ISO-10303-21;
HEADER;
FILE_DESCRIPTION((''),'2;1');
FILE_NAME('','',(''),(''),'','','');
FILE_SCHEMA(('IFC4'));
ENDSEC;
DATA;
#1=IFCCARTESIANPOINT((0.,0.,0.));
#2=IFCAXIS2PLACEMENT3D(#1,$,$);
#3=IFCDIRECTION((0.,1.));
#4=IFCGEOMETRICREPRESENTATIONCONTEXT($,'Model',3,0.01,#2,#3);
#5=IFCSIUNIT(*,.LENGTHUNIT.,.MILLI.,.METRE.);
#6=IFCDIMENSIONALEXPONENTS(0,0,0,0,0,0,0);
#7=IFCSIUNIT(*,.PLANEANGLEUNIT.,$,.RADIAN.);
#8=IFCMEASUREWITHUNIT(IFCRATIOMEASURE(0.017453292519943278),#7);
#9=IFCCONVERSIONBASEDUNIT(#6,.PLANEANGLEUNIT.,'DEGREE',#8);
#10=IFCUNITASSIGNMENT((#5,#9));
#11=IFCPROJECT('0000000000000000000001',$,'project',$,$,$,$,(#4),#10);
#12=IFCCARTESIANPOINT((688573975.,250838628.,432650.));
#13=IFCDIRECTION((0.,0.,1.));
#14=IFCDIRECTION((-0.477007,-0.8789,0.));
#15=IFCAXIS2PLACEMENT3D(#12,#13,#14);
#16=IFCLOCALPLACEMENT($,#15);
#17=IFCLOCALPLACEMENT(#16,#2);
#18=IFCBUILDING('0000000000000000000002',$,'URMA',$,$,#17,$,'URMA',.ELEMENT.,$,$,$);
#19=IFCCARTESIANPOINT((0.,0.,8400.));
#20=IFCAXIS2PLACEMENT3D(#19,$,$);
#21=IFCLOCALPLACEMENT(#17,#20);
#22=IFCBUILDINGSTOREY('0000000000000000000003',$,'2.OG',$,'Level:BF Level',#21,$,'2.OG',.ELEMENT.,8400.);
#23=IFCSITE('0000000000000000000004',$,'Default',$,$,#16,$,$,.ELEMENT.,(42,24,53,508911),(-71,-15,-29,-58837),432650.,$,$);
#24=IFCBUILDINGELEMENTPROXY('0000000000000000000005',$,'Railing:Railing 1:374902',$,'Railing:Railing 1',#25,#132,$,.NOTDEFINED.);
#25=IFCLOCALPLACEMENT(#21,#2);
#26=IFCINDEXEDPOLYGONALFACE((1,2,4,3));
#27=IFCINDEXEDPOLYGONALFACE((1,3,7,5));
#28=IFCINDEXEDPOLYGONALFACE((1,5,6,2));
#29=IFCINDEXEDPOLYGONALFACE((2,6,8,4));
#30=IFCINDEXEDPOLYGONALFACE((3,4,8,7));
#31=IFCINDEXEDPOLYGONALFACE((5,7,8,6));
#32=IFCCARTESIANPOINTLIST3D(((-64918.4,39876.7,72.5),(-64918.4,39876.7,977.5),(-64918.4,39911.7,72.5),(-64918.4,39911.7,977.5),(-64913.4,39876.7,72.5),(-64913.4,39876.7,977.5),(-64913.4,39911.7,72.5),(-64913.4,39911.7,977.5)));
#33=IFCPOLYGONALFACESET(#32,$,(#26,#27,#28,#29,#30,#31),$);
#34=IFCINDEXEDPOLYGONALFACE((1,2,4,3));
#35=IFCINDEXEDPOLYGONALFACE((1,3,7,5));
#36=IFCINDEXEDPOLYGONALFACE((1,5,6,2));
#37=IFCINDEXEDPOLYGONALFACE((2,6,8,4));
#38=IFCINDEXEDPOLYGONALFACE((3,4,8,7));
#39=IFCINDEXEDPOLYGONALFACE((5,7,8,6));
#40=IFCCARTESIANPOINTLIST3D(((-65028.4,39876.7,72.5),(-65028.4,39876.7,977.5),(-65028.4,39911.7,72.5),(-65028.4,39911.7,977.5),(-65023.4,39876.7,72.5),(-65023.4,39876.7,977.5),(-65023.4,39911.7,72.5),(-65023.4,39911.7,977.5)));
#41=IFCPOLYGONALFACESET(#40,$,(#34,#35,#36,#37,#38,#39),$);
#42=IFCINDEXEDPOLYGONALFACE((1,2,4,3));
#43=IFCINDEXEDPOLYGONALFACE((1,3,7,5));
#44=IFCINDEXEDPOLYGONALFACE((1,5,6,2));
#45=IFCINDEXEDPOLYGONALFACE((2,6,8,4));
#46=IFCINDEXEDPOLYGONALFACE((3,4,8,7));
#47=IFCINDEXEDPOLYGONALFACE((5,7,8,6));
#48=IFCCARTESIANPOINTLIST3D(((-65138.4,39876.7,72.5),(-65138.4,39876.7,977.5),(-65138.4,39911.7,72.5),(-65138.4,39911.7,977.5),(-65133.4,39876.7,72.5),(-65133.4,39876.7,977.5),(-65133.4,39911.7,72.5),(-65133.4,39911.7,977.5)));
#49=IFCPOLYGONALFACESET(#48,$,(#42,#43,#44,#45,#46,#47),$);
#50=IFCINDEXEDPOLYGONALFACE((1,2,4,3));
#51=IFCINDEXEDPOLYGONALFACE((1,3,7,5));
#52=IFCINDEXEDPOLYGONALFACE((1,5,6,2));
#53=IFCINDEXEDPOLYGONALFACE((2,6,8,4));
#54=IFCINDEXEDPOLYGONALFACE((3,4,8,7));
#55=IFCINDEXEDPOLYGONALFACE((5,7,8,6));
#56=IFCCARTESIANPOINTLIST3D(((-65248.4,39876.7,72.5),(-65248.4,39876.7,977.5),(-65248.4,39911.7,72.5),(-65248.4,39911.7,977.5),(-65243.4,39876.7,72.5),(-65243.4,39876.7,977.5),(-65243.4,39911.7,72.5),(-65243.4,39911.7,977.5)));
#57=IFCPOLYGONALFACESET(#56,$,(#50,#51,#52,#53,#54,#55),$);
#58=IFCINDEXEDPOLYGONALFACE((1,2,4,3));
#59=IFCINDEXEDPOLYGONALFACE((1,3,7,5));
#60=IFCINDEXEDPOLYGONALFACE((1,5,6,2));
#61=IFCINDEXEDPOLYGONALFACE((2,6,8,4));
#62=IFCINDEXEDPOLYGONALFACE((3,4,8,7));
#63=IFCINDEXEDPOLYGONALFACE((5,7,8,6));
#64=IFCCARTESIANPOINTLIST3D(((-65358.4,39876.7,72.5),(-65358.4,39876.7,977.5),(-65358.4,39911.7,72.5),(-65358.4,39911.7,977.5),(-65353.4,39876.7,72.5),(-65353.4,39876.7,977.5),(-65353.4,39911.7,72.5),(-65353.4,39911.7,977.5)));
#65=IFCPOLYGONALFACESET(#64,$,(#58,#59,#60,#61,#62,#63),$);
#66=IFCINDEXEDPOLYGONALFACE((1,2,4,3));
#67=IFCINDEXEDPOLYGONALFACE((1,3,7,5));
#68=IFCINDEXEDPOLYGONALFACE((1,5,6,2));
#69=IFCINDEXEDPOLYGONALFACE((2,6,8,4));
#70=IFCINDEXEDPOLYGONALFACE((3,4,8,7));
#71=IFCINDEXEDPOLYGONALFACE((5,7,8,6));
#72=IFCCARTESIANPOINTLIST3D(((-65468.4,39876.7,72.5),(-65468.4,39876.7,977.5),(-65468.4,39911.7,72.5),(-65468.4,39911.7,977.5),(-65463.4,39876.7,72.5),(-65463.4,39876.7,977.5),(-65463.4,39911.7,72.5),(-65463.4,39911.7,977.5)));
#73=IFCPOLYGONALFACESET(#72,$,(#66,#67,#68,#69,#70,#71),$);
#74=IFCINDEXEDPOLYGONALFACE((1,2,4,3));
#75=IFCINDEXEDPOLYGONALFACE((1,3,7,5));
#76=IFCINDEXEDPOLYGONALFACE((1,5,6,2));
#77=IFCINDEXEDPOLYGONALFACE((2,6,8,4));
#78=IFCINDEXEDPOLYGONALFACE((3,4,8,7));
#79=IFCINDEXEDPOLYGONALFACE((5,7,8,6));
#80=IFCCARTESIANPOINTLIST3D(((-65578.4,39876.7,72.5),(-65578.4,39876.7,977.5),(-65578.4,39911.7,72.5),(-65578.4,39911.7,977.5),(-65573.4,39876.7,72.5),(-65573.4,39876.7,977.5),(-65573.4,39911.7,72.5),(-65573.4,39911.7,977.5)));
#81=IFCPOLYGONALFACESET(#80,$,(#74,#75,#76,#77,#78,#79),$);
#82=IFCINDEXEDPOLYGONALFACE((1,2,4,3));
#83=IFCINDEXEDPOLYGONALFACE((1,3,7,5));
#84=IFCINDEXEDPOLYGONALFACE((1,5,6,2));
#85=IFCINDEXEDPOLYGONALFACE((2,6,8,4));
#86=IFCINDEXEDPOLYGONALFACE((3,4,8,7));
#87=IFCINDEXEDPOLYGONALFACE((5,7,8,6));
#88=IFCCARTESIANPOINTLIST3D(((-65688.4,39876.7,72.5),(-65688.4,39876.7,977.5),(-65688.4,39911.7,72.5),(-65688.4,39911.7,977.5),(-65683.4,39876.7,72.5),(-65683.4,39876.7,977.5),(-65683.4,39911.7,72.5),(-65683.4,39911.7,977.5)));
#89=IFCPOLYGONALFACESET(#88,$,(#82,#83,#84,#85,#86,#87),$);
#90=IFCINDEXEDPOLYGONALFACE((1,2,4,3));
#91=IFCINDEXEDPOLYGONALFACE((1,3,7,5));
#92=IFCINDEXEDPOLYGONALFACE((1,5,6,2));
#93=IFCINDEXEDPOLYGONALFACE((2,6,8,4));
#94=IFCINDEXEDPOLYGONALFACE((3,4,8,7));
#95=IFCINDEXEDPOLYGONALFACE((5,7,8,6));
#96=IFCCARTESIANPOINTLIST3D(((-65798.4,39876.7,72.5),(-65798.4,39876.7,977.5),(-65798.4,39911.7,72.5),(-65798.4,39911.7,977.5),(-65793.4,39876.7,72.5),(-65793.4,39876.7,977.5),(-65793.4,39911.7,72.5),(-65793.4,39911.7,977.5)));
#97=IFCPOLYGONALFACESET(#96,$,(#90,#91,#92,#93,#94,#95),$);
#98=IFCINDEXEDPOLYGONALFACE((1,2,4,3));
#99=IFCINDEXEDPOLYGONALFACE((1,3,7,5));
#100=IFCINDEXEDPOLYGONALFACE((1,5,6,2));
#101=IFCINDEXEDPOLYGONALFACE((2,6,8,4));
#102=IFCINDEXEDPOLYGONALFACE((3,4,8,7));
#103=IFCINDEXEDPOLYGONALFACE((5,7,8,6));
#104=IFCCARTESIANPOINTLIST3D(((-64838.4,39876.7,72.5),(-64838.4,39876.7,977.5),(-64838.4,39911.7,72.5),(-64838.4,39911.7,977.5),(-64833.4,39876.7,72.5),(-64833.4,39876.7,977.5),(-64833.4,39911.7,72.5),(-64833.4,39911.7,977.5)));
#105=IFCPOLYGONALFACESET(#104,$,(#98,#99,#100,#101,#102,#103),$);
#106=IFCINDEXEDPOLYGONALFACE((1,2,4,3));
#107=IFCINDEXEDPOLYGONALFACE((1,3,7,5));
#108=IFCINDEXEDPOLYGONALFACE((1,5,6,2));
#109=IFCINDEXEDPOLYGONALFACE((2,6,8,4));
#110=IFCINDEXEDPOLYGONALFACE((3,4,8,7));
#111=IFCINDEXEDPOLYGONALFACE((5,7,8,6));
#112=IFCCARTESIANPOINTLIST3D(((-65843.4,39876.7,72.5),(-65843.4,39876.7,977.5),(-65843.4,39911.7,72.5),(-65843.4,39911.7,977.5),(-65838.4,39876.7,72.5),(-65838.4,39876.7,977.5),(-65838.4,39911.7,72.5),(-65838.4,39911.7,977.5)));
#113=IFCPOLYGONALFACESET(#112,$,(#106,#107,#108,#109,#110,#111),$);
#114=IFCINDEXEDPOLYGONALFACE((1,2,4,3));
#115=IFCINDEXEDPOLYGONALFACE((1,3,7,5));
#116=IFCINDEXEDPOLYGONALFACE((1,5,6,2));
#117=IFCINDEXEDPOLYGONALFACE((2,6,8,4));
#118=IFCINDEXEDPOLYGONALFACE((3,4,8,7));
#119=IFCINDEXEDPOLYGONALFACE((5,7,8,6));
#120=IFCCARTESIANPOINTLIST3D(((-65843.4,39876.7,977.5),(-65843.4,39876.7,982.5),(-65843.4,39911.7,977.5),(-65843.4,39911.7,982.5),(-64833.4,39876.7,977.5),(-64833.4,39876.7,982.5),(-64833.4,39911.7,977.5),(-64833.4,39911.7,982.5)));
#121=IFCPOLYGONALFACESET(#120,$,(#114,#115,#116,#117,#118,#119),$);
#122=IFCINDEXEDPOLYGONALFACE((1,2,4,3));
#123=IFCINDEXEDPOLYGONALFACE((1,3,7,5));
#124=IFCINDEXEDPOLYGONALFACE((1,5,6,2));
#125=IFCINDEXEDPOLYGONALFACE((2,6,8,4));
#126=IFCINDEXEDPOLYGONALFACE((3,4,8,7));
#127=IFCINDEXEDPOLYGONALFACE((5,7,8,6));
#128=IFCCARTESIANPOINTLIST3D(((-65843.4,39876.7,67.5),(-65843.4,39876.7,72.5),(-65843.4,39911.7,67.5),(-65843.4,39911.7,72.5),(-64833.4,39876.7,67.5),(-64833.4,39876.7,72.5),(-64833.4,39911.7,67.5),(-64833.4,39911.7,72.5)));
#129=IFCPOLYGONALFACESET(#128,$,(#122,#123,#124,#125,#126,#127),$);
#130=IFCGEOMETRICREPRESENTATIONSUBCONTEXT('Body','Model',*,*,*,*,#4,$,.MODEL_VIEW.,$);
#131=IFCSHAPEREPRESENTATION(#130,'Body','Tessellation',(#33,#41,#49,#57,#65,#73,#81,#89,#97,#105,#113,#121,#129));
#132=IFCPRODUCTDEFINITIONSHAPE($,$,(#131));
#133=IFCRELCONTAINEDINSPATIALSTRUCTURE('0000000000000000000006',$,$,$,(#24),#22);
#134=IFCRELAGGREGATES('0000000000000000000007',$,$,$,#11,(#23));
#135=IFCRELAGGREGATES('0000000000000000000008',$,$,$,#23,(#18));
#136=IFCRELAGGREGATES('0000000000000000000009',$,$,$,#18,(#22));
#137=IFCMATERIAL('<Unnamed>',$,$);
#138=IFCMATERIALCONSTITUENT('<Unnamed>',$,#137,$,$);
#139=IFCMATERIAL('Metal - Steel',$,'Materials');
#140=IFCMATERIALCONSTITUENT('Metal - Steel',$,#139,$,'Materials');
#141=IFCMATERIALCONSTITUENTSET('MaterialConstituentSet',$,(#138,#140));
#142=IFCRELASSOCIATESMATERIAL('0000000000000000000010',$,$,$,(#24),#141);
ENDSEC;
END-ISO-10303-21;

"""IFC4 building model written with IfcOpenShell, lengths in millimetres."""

from ifc_helpers import new_model, entity, si_unit, converted_unit, direction, frame, origin, place, context, subcontext, project, spatial, indexed_curve, outline, extrude, material, constituent, constituent_set, element, save


model = new_model("IFC4")

# Units and contexts
model_context = context("Model", 3, precision=0.01, world=origin(), true_north=direction((0.0, 1.0)))
body_context = subcontext(model_context, "Body", "Model", "MODEL_VIEW")
ifc_project = project(units=[si_unit("LENGTHUNIT", "METRE", prefix="MILLI"), converted_unit("PLANEANGLEUNIT", "DEGREE", entity("IfcRatioMeasure", 0.017453292519943278), si_unit("PLANEANGLEUNIT", "RADIAN"), dimensions=[0, 0, 0, 0, 0, 0, 0])], contexts=[model_context])

# Site, building, storey
site_placement = place(None, frame((688573975.0, 250838628.0, 432650.0), z_axis=(0.0, 0.0, 1.0), x_axis=(-0.477007, -0.8789, 0.0)))
site = spatial("IfcSite", under=ifc_project, at=site_placement, Name="Default", CompositionType="ELEMENT", RefLatitude=(42, 24, 53, 508911), RefLongitude=(-71, -15, -29, -58837), RefElevation=432650.0)
building_placement = place(site_placement, origin())
building = spatial("IfcBuilding", under=site, at=building_placement, Name="URMA", LongName="URMA", CompositionType="ELEMENT")
storey_placement = place(building_placement, frame((0.0, 0.0, 8400.0)))
storey = spatial("IfcBuildingStorey", under=building, at=storey_placement, Name="2.OG", ObjectType="Level:BF Level", LongName="2.OG", CompositionType="ELEMENT", Elevation=8400.0)

# Building element proxy
ifc_material_1 = material(Name="<Unnamed>")
ifc_material_2 = material(Name="Metal - Steel", Category="Materials")
ifc_constituent_1 = constituent(ifc_material_1, Name="<Unnamed>")
ifc_constituent_2 = constituent(ifc_material_2, Name="Metal - Steel", Category="Materials")
ifc_constituent_set_1 = constituent_set(constituents=[ifc_constituent_1, ifc_constituent_2], Name="MaterialConstituentSet")
proxy_1_placement = place(storey_placement, origin())
element("IfcBuildingElementProxy", 1, at=proxy_1_placement, inside=storey, material=ifc_constituent_set_1, Name="Railing:Railing 1:374902", ObjectType="Railing:Railing 1", PredefinedType="NOTDEFINED", context=body_context, shape_type="SweptSolid", body=[
    extrude(outline(indexed_curve([(-17.5, -2.5), (17.5, -2.5), (17.5, 2.5), (-17.5, 2.5), (-17.5, -2.5)], self_intersect=False)), frame((-64915.9, 39894.2, 72.5), z_axis=(0.0, 0.0, 1.0), x_axis=(0.0, 1.0, 0.0)), (0.0, 0.0, 1.0), 905.0),
    extrude(outline(indexed_curve([(-17.5, -2.5), (17.5, -2.5), (17.5, 2.5), (-17.5, 2.5), (-17.5, -2.5)], self_intersect=False)), frame((-65025.9, 39894.2, 72.5), z_axis=(0.0, 0.0, 1.0), x_axis=(0.0, 1.0, 0.0)), (0.0, 0.0, 1.0), 905.0),
    extrude(outline(indexed_curve([(-17.5, -2.5), (17.5, -2.5), (17.5, 2.5), (-17.5, 2.5), (-17.5, -2.5)], self_intersect=False)), frame((-65135.9, 39894.2, 72.5), z_axis=(0.0, 0.0, 1.0), x_axis=(0.0, 1.0, 0.0)), (0.0, 0.0, 1.0), 905.0),
    extrude(outline(indexed_curve([(-17.5, -2.5), (17.5, -2.5), (17.5, 2.5), (-17.5, 2.5), (-17.5, -2.5)], self_intersect=False)), frame((-65245.9, 39894.2, 72.5), z_axis=(0.0, 0.0, 1.0), x_axis=(0.0, 1.0, 0.0)), (0.0, 0.0, 1.0), 905.0),
    extrude(outline(indexed_curve([(-17.5, -2.5), (17.5, -2.5), (17.5, 2.5), (-17.5, 2.5), (-17.5, -2.5)], self_intersect=False)), frame((-65355.9, 39894.2, 72.5), z_axis=(0.0, 0.0, 1.0), x_axis=(0.0, 1.0, 0.0)), (0.0, 0.0, 1.0), 905.0),
    extrude(outline(indexed_curve([(-17.5, -2.5), (17.5, -2.5), (17.5, 2.5), (-17.5, 2.5), (-17.5, -2.5)], self_intersect=False)), frame((-65465.9, 39894.2, 72.5), z_axis=(0.0, 0.0, 1.0), x_axis=(0.0, 1.0, 0.0)), (0.0, 0.0, 1.0), 905.0),
    extrude(outline(indexed_curve([(-17.5, -2.5), (17.5, -2.5), (17.5, 2.5), (-17.5, 2.5), (-17.5, -2.5)], self_intersect=False)), frame((-65575.9, 39894.2, 72.5), z_axis=(0.0, 0.0, 1.0), x_axis=(0.0, 1.0, 0.0)), (0.0, 0.0, 1.0), 905.0),
    extrude(outline(indexed_curve([(-17.5, -2.5), (17.5, -2.5), (17.5, 2.5), (-17.5, 2.5), (-17.5, -2.5)], self_intersect=False)), frame((-65685.9, 39894.2, 72.5), z_axis=(0.0, 0.0, 1.0), x_axis=(0.0, 1.0, 0.0)), (0.0, 0.0, 1.0), 905.0),
    extrude(outline(indexed_curve([(-17.5, -2.5), (17.5, -2.5), (17.5, 2.5), (-17.5, 2.5), (-17.5, -2.5)], self_intersect=False)), frame((-65795.9, 39894.2, 72.5), z_axis=(0.0, 0.0, 1.0), x_axis=(0.0, 1.0, 0.0)), (0.0, 0.0, 1.0), 905.0),
    extrude(outline(indexed_curve([(-17.5, -2.5), (17.5, -2.5), (17.5, 2.5), (-17.5, 2.5), (-17.5, -2.5)], self_intersect=False)), frame((-64835.9, 39894.2, 72.5), z_axis=(0.0, 0.0, 1.0), x_axis=(0.0, 1.0, 0.0)), (0.0, 0.0, 1.0), 905.0),
    extrude(outline(indexed_curve([(-17.5, -2.5), (17.5, -2.5), (17.5, 2.5), (-17.5, 2.5), (-17.5, -2.5)], self_intersect=False)), frame((-65840.9, 39894.2, 72.5), z_axis=(0.0, 0.0, 1.0), x_axis=(0.0, 1.0, 0.0)), (0.0, 0.0, 1.0), 905.0),
    extrude(outline(indexed_curve([(-505.0, -17.5), (505.0, -17.5), (505.0, 17.5), (-505.0, 17.5), (-505.0, -17.5)], self_intersect=False)), frame((-65338.4, 39894.2, 977.5)), (0.0, 0.0, 1.0), 5.0),
    extrude(outline(indexed_curve([(-505.0, -17.5), (505.0, -17.5), (505.0, 17.5), (-505.0, 17.5), (-505.0, -17.5)], self_intersect=False)), frame((-65338.4, 39894.2, 67.5)), (0.0, 0.0, 1.0), 5.0),
])

save(model, "model.ifc")
